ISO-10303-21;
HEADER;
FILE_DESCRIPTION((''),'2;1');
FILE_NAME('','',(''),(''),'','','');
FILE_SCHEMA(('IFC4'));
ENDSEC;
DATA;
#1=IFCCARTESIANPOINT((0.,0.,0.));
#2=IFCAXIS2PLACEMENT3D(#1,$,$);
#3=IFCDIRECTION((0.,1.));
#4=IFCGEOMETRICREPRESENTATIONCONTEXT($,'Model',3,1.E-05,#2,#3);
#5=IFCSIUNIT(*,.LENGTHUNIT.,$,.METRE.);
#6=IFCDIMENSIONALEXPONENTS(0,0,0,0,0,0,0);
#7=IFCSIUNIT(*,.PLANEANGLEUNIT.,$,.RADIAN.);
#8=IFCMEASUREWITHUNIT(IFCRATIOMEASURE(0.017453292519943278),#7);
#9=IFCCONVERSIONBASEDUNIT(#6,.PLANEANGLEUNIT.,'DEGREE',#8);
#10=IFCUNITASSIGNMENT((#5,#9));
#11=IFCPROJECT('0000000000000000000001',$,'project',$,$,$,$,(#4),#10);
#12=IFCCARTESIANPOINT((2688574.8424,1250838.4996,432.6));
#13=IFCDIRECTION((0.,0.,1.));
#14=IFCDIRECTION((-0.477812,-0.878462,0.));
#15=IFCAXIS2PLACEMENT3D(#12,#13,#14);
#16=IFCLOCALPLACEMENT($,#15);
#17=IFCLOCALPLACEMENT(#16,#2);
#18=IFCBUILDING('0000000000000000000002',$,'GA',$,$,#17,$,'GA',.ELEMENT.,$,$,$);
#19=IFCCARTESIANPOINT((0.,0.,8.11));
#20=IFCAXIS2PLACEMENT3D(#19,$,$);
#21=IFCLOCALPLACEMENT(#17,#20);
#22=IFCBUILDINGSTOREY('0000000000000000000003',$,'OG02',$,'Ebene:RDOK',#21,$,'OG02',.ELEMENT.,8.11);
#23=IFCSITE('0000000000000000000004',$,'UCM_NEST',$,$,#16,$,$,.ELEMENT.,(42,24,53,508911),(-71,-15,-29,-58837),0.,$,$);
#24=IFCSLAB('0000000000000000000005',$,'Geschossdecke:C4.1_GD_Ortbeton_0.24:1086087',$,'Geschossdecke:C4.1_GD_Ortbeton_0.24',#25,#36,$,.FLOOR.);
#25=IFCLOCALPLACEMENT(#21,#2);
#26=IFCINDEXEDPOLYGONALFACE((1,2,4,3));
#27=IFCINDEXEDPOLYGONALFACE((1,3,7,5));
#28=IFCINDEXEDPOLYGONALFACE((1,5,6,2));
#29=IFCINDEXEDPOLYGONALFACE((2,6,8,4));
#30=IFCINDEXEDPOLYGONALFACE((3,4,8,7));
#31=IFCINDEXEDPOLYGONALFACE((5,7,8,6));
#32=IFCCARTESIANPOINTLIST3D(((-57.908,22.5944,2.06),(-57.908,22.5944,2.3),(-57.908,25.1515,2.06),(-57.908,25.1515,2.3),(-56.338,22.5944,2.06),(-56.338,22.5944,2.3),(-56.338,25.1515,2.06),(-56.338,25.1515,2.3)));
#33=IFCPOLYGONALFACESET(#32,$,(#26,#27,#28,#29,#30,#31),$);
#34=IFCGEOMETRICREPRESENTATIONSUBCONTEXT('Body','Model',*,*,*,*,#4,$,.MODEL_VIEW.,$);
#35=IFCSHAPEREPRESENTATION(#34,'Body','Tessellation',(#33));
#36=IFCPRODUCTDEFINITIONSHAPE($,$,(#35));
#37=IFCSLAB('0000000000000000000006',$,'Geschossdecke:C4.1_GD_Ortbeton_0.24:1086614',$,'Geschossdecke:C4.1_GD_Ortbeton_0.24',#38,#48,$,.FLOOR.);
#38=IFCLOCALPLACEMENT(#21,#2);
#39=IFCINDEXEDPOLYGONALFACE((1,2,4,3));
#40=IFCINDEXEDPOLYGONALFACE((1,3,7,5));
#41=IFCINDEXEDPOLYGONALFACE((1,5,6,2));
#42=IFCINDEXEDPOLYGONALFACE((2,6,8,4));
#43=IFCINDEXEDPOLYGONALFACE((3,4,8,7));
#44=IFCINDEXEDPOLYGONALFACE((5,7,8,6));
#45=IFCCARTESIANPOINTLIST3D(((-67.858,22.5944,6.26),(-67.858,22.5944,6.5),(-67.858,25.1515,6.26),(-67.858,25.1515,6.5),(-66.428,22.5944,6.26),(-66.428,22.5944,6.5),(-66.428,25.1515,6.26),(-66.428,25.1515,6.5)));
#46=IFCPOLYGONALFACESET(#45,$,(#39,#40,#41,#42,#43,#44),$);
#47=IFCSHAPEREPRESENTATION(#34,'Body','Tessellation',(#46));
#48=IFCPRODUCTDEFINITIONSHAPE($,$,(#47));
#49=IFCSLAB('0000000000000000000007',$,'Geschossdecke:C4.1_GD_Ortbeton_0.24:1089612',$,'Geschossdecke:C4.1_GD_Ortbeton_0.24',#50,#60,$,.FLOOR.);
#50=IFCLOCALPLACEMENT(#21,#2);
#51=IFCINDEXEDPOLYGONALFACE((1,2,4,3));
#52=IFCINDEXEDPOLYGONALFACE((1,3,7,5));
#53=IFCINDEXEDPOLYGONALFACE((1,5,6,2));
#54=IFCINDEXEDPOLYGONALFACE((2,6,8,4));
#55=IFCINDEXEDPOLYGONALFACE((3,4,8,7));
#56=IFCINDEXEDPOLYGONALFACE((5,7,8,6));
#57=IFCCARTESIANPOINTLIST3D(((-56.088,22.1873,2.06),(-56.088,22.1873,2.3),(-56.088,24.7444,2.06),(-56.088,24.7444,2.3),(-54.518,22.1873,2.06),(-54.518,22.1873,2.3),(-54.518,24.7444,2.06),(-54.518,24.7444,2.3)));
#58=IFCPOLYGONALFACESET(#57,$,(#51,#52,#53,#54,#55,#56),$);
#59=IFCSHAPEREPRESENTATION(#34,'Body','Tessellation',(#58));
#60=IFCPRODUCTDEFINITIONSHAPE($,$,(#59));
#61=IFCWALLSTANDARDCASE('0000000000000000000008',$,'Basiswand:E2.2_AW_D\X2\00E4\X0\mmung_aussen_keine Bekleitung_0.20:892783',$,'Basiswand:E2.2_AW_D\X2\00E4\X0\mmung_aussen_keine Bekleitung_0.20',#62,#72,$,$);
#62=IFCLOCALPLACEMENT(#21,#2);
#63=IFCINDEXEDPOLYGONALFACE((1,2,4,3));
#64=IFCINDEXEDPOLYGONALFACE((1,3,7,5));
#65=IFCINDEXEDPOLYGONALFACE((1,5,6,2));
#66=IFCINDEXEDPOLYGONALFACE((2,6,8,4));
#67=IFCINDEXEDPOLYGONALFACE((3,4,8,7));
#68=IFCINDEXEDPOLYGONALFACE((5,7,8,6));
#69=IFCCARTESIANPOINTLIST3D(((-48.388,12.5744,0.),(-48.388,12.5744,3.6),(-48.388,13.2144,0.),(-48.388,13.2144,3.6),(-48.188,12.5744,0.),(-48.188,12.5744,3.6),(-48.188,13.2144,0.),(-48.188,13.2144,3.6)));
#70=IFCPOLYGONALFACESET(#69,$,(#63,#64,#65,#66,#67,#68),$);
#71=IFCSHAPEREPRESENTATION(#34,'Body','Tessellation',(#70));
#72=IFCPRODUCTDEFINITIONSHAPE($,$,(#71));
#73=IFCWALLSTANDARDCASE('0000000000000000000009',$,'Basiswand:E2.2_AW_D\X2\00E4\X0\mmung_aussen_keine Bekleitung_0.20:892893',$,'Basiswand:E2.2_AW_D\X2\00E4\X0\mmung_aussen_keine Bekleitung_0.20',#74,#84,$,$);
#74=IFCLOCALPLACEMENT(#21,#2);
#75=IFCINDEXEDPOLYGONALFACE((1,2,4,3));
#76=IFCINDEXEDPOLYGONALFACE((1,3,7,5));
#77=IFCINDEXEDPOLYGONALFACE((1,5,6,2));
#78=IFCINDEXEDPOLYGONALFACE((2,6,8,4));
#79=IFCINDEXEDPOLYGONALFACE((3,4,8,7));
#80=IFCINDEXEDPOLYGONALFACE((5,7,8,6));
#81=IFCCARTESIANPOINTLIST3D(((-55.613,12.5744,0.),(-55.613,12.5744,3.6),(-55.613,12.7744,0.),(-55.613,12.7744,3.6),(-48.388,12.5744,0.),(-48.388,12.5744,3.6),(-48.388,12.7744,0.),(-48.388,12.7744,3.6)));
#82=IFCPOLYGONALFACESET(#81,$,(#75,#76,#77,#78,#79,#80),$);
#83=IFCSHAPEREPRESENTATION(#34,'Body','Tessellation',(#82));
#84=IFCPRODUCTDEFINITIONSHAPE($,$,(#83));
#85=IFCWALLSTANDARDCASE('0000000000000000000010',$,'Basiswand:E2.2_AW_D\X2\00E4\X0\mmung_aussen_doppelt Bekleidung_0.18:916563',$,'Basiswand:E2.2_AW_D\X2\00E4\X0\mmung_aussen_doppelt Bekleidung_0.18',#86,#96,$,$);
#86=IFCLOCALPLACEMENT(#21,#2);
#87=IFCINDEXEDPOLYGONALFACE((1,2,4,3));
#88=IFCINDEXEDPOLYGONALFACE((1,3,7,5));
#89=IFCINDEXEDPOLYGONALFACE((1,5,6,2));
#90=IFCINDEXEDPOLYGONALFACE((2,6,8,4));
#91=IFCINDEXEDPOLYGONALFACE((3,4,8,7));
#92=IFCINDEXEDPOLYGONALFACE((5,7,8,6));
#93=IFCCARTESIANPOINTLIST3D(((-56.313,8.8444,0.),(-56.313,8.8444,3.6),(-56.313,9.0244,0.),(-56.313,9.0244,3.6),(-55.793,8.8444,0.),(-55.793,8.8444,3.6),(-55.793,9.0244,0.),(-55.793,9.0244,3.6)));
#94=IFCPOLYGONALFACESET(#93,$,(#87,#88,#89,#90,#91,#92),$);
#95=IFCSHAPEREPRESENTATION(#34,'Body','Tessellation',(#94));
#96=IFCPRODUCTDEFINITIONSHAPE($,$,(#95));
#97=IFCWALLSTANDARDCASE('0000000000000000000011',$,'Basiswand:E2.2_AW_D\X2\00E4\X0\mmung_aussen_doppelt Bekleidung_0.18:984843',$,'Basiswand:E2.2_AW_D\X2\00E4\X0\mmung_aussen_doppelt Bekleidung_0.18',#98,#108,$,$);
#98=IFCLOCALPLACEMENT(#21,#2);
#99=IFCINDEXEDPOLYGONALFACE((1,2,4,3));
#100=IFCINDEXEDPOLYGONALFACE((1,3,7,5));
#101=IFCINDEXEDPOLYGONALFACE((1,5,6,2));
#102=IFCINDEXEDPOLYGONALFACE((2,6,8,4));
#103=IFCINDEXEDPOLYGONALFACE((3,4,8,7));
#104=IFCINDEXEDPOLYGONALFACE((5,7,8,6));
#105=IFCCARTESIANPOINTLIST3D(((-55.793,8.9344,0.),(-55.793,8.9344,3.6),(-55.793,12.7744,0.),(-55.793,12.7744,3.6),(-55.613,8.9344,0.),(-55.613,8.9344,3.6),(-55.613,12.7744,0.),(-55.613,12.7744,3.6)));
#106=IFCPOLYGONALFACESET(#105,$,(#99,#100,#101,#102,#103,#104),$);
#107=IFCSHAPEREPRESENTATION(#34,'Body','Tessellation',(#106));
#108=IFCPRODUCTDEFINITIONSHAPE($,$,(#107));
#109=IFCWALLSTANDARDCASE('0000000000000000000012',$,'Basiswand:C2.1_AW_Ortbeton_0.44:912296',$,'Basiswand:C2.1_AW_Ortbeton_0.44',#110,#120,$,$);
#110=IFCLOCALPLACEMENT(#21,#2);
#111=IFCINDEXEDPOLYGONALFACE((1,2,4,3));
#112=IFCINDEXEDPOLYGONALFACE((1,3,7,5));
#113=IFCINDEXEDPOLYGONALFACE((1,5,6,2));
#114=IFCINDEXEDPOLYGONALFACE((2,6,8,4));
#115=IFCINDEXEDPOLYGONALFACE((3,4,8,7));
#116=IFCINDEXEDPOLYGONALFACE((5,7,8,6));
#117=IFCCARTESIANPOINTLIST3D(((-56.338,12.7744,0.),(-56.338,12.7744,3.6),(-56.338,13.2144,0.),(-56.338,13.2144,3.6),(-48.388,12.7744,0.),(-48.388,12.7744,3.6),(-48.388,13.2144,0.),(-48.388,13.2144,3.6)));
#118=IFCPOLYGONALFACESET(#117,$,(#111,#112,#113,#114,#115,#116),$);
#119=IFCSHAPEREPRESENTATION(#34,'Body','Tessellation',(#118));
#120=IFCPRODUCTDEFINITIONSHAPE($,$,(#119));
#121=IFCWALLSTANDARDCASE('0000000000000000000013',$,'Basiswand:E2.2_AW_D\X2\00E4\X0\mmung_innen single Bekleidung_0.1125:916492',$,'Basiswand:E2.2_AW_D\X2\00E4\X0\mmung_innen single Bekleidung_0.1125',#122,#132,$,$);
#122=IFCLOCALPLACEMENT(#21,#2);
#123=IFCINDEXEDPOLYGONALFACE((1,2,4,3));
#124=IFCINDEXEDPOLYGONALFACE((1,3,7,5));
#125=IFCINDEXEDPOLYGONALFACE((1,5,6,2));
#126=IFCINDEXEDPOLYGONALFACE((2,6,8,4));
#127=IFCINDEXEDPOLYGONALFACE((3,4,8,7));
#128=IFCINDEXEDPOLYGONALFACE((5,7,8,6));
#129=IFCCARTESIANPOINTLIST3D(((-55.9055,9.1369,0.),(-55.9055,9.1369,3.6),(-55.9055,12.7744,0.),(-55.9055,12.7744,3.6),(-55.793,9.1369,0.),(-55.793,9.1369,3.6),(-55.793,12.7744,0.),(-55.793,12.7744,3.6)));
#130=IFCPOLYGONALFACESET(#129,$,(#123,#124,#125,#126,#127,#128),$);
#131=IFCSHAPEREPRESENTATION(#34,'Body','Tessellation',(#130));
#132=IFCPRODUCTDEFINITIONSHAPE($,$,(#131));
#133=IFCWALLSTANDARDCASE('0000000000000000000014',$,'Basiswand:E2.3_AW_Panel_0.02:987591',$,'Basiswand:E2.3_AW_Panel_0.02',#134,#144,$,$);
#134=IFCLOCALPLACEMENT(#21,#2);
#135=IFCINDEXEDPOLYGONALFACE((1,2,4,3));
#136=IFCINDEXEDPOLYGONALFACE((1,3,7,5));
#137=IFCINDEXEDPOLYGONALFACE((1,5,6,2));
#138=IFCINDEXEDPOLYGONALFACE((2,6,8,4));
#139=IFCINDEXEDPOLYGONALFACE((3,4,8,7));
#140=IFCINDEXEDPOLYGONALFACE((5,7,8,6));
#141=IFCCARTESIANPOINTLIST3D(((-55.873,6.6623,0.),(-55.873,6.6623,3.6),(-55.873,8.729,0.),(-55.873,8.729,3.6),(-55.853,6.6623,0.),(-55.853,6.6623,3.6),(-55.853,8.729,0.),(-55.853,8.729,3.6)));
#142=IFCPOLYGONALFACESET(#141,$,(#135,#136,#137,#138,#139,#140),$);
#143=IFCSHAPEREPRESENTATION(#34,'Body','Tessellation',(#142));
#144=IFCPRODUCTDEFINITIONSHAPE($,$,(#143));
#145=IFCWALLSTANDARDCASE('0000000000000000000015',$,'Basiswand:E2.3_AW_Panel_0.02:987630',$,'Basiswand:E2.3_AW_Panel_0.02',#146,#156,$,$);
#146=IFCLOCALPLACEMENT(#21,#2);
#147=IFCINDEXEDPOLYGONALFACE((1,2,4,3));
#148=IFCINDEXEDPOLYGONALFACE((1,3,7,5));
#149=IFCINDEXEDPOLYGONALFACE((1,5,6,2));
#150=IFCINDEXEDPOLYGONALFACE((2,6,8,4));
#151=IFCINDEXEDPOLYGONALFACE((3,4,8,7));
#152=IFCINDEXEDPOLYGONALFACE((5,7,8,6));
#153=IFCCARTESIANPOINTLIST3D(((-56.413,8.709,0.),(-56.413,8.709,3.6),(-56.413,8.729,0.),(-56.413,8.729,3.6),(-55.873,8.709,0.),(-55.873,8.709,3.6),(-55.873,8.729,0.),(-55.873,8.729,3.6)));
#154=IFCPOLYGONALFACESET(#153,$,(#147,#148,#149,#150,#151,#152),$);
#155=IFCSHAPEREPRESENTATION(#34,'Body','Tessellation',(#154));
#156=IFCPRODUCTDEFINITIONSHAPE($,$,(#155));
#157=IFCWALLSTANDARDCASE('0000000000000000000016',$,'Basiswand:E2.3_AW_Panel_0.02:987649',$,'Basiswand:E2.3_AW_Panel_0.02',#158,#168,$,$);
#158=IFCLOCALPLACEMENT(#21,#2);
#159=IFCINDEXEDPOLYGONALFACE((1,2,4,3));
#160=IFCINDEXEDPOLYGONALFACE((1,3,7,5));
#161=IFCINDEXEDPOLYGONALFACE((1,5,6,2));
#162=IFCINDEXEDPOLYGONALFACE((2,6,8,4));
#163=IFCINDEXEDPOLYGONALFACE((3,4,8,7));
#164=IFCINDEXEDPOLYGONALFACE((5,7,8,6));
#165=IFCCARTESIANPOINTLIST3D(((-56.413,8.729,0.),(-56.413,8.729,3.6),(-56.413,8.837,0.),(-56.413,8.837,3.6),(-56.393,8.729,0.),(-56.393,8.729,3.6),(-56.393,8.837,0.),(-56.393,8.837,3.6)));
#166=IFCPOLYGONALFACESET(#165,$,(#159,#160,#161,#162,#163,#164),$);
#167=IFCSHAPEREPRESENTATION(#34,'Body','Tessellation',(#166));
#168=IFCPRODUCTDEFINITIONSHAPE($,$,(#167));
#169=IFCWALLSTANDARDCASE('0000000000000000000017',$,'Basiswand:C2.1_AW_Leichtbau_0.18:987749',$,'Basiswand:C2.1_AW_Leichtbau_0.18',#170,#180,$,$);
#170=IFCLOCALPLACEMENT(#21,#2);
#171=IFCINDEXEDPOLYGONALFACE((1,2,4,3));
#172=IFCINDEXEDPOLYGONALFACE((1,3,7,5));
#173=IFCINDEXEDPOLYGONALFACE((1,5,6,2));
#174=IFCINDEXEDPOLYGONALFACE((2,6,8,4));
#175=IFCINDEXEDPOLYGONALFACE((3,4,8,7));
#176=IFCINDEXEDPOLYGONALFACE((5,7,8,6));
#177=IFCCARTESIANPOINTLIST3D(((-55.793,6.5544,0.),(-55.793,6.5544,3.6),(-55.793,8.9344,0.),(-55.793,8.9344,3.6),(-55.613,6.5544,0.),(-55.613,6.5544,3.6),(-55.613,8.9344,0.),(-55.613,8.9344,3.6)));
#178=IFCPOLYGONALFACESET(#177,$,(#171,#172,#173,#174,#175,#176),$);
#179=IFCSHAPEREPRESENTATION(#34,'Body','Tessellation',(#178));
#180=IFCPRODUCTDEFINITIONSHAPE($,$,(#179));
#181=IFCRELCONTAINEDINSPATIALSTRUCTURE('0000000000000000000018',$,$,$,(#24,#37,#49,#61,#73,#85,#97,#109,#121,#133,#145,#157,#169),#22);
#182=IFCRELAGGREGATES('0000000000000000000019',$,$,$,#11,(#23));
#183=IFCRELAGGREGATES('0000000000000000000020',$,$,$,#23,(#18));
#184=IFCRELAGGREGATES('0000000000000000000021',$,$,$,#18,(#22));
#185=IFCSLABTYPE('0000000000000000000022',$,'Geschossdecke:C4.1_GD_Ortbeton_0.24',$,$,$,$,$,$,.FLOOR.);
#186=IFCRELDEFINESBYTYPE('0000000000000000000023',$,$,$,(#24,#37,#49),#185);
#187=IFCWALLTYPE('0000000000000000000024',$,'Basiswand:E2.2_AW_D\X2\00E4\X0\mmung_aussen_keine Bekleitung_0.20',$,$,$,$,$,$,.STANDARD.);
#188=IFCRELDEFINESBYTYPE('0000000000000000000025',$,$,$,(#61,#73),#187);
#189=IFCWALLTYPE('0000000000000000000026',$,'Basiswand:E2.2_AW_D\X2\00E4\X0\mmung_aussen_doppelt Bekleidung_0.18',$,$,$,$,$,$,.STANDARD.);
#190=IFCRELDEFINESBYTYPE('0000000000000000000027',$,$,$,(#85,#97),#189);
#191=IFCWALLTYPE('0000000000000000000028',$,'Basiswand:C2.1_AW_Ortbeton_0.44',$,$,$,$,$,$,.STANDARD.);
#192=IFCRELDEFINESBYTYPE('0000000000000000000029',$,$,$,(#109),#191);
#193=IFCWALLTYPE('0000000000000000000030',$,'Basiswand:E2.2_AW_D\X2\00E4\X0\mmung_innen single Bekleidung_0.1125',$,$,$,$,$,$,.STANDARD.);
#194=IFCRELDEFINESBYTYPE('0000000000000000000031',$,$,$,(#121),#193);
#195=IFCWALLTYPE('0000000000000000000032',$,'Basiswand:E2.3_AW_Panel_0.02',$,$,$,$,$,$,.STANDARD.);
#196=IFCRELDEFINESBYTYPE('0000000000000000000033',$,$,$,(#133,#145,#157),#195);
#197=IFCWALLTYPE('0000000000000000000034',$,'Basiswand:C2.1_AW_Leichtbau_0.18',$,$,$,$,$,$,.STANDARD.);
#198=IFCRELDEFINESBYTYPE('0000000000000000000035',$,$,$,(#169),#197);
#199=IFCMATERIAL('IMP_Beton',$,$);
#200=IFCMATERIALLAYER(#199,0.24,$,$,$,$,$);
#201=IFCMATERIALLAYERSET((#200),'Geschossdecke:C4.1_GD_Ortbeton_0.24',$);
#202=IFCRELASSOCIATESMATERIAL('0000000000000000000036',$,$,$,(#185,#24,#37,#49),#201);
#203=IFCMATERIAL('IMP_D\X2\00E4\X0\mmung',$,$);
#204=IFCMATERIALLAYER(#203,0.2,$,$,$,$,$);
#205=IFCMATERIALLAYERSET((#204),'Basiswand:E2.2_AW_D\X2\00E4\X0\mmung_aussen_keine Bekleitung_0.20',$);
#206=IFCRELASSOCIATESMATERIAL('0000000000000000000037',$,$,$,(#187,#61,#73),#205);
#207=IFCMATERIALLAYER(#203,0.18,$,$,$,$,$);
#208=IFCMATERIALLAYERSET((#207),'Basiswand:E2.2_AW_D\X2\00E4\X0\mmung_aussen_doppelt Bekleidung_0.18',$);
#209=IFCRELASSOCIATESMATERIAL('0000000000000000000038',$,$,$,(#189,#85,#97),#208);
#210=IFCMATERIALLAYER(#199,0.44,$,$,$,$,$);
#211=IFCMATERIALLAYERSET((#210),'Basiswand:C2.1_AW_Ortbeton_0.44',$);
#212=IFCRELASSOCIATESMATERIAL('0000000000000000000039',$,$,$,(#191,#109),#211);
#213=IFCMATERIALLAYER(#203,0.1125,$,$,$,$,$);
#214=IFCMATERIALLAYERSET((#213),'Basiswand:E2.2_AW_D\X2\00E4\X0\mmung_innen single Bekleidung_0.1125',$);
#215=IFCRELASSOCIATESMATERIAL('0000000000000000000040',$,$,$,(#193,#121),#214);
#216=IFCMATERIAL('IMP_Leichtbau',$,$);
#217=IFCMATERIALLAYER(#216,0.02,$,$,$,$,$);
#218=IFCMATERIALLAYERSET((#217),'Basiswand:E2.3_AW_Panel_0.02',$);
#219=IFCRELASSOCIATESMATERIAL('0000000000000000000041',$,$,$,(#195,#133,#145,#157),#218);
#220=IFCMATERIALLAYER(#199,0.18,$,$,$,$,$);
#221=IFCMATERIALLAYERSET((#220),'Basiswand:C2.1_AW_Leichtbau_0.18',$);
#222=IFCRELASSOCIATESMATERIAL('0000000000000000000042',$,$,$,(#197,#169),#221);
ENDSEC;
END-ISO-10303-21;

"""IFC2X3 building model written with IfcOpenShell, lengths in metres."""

from ifc_helpers import new_model, entity, si_unit, converted_unit, direction, frame, frame_2d, origin, place, context, subcontext, project, spatial, rectangle, extrude, material, layer, layer_set, layer_usage, type_object, element, save


model = new_model("IFC2X3")

# Units and contexts
model_context = context("Model", 3, precision=1e-05, world=origin(), true_north=direction((0.0, 1.0)))
body_context = subcontext(model_context, "Body", "Model", "MODEL_VIEW")
ifc_project = project(units=[si_unit("LENGTHUNIT", "METRE"), converted_unit("PLANEANGLEUNIT", "DEGREE", entity("IfcRatioMeasure", 0.017453292519943278), si_unit("PLANEANGLEUNIT", "RADIAN"), dimensions=[0, 0, 0, 0, 0, 0, 0])], contexts=[model_context])

# Site, building, storey
site_placement = place(None, frame((2688574.8424, 1250838.4996, 432.6), z_axis=(0.0, 0.0, 1.0), x_axis=(-0.477812, -0.878462, 0.0)))
site = spatial("IfcSite", under=ifc_project, at=site_placement, Name="UCM_NEST", CompositionType="ELEMENT", RefLatitude=(42, 24, 53, 508911), RefLongitude=(-71, -15, -29, -58837), RefElevation=0.0)
building_placement = place(site_placement, origin())
building = spatial("IfcBuilding", under=site, at=building_placement, Name="GA", LongName="GA", CompositionType="ELEMENT")
storey_placement = place(building_placement, frame((0.0, 0.0, 8.11)))
storey = spatial("IfcBuildingStorey", under=building, at=storey_placement, Name="OG02", ObjectType="Ebene:RDOK", LongName="OG02", CompositionType="ELEMENT", Elevation=8.11)

# Shared definitions
ifc_material_1 = material(Name="IMP_Beton")
ifc_material_2 = material(Name="IMP_Dämmung")

# Slabs
ifc_layer_1 = layer(ifc_material_1, 0.24)
ifc_layer_set_1 = layer_set([ifc_layer_1], Name="Geschossdecke:C4.1_GD_Ortbeton_0.24")
ifc_layer_usage_1 = layer_usage(ifc_layer_set_1, "AXIS3", "POSITIVE", 0.0)
slab_type_1 = type_object("IfcSlabType", Name="Geschossdecke:C4.1_GD_Ortbeton_0.24", PredefinedType="FLOOR", material=ifc_layer_set_1)
slab_1_placement = place(storey_placement, origin())
element("IfcSlab", 1, at=slab_1_placement, inside=storey, type_object=slab_type_1, material=ifc_layer_usage_1, Name="Geschossdecke:C4.1_GD_Ortbeton_0.24:1086087", ObjectType="Geschossdecke:C4.1_GD_Ortbeton_0.24", PredefinedType="FLOOR", context=body_context, shape_type="SweptSolid", body=[
    extrude(rectangle(XDim=2.5571, YDim=1.57, at=frame_2d((0.0, 0.0), x_axis=(1.0, 0.0))), frame((-57.123, 23.873, 2.3), z_axis=(0.0, 0.0, -1.0), x_axis=(0.0, 1.0, 0.0)), (0.0, 0.0, 1.0), 0.24),
])
slab_2_placement = place(storey_placement, origin())
element("IfcSlab", 2, at=slab_2_placement, inside=storey, type_object=slab_type_1, material=ifc_layer_usage_1, Name="Geschossdecke:C4.1_GD_Ortbeton_0.24:1086614", ObjectType="Geschossdecke:C4.1_GD_Ortbeton_0.24", PredefinedType="FLOOR", context=body_context, shape_type="SweptSolid", body=[
    extrude(rectangle(XDim=2.5571, YDim=1.43, at=frame_2d((0.0, 0.0), x_axis=(1.0, 0.0))), frame((-67.143, 23.873, 6.5), z_axis=(0.0, 0.0, -1.0), x_axis=(0.0, 1.0, 0.0)), (0.0, 0.0, 1.0), 0.24),
])
slab_3_placement = place(storey_placement, origin())
element("IfcSlab", 3, at=slab_3_placement, inside=storey, type_object=slab_type_1, material=ifc_layer_usage_1, Name="Geschossdecke:C4.1_GD_Ortbeton_0.24:1089612", ObjectType="Geschossdecke:C4.1_GD_Ortbeton_0.24", PredefinedType="FLOOR", context=body_context, shape_type="SweptSolid", body=[
    extrude(rectangle(XDim=2.5571, YDim=1.57, at=frame_2d((0.0, 0.0), x_axis=(1.0, 0.0))), frame((-55.303, 23.4659, 2.3), z_axis=(0.0, 0.0, -1.0), x_axis=(0.0, 1.0, 0.0)), (0.0, 0.0, 1.0), 0.24),
])

# Walls
ifc_layer_2 = layer(ifc_material_2, 0.2)
ifc_layer_set_2 = layer_set([ifc_layer_2], Name="Basiswand:E2.2_AW_Dämmung_aussen_keine Bekleitung_0.20")
ifc_layer_usage_2 = layer_usage(ifc_layer_set_2, "AXIS2", "NEGATIVE", 0.1)
wall_type_1 = type_object("IfcWallType", Name="Basiswand:E2.2_AW_Dämmung_aussen_keine Bekleitung_0.20", PredefinedType="STANDARD", material=ifc_layer_set_2)
wall_1_placement = place(storey_placement, frame((-48.288, 13.2144, 0.0), z_axis=(0.0, 0.0, 1.0), x_axis=(0.0, -1.0, 0.0)))
element("IfcWallStandardCase", 4, at=wall_1_placement, inside=storey, type_object=wall_type_1, material=ifc_layer_usage_2, Name="Basiswand:E2.2_AW_Dämmung_aussen_keine Bekleitung_0.20:892783", ObjectType="Basiswand:E2.2_AW_Dämmung_aussen_keine Bekleitung_0.20", context=body_context, shape_type="SweptSolid", body=[
    extrude(rectangle(XDim=0.64, YDim=0.2, at=frame_2d((0.32, 0.0), x_axis=(-1.0, 0.0))), origin(), (0.0, 0.0, 1.0), 3.6),
])
wall_2_placement = place(storey_placement, frame((-48.388, 12.6744, 0.0), z_axis=(0.0, 0.0, 1.0), x_axis=(-1.0, 0.0, 0.0)))
element("IfcWallStandardCase", 5, at=wall_2_placement, inside=storey, type_object=wall_type_1, material=ifc_layer_usage_2, Name="Basiswand:E2.2_AW_Dämmung_aussen_keine Bekleitung_0.20:892893", ObjectType="Basiswand:E2.2_AW_Dämmung_aussen_keine Bekleitung_0.20", context=body_context, shape_type="SweptSolid", body=[
    extrude(rectangle(XDim=7.225, YDim=0.2, at=frame_2d((3.6125, 0.0), x_axis=(-1.0, 0.0))), origin(), (0.0, 0.0, 1.0), 3.6),
])
ifc_layer_3 = layer(ifc_material_2, 0.18)
ifc_layer_set_3 = layer_set([ifc_layer_3], Name="Basiswand:E2.2_AW_Dämmung_aussen_doppelt Bekleidung_0.18")
ifc_layer_usage_3 = layer_usage(ifc_layer_set_3, "AXIS2", "NEGATIVE", 0.09)
wall_type_2 = type_object("IfcWallType", Name="Basiswand:E2.2_AW_Dämmung_aussen_doppelt Bekleidung_0.18", PredefinedType="STANDARD", material=ifc_layer_set_3)
wall_3_placement = place(storey_placement, frame((-56.313, 8.9344, 0.0)))
element("IfcWallStandardCase", 6, at=wall_3_placement, inside=storey, type_object=wall_type_2, material=ifc_layer_usage_3, Name="Basiswand:E2.2_AW_Dämmung_aussen_doppelt Bekleidung_0.18:916563", ObjectType="Basiswand:E2.2_AW_Dämmung_aussen_doppelt Bekleidung_0.18", context=body_context, shape_type="SweptSolid", body=[
    extrude(rectangle(XDim=0.52, YDim=0.18, at=frame_2d((0.26, 0.0), x_axis=(-1.0, 0.0))), origin(), (0.0, 0.0, 1.0), 3.6),
])
wall_4_placement = place(storey_placement, frame((-55.703, 8.9344, 0.0), z_axis=(0.0, 0.0, 1.0), x_axis=(0.0, 1.0, 0.0)))
element("IfcWallStandardCase", 7, at=wall_4_placement, inside=storey, type_object=wall_type_2, material=ifc_layer_usage_3, Name="Basiswand:E2.2_AW_Dämmung_aussen_doppelt Bekleidung_0.18:984843", ObjectType="Basiswand:E2.2_AW_Dämmung_aussen_doppelt Bekleidung_0.18", context=body_context, shape_type="SweptSolid", body=[
    extrude(rectangle(XDim=3.84, YDim=0.18, at=frame_2d((1.92, 0.0), x_axis=(-1.0, 0.0))), origin(), (0.0, 0.0, 1.0), 3.6),
])
ifc_layer_4 = layer(ifc_material_1, 0.44)
ifc_layer_set_4 = layer_set([ifc_layer_4], Name="Basiswand:C2.1_AW_Ortbeton_0.44")
ifc_layer_usage_4 = layer_usage(ifc_layer_set_4, "AXIS2", "NEGATIVE", 0.22)
wall_type_3 = type_object("IfcWallType", Name="Basiswand:C2.1_AW_Ortbeton_0.44", PredefinedType="STANDARD", material=ifc_layer_set_4)
wall_5_placement = place(storey_placement, frame((-48.388, 12.9944, 0.0), z_axis=(0.0, 0.0, 1.0), x_axis=(-1.0, 0.0, 0.0)))
element("IfcWallStandardCase", 8, at=wall_5_placement, inside=storey, type_object=wall_type_3, material=ifc_layer_usage_4, Name="Basiswand:C2.1_AW_Ortbeton_0.44:912296", ObjectType="Basiswand:C2.1_AW_Ortbeton_0.44", context=body_context, shape_type="SweptSolid", body=[
    extrude(rectangle(XDim=7.95, YDim=0.44, at=frame_2d((3.975, 0.0), x_axis=(-1.0, 0.0))), origin(), (0.0, 0.0, 1.0), 3.6),
])
ifc_layer_5 = layer(ifc_material_2, 0.1125)
ifc_layer_set_5 = layer_set([ifc_layer_5], Name="Basiswand:E2.2_AW_Dämmung_innen single Bekleidung_0.1125")
ifc_layer_usage_5 = layer_usage(ifc_layer_set_5, "AXIS2", "NEGATIVE", 0.0562)
wall_type_4 = type_object("IfcWallType", Name="Basiswand:E2.2_AW_Dämmung_innen single Bekleidung_0.1125", PredefinedType="STANDARD", material=ifc_layer_set_5)
wall_6_placement = place(storey_placement, frame((-55.8493, 9.1369, 0.0), z_axis=(0.0, 0.0, 1.0), x_axis=(0.0, 1.0, 0.0)))
element("IfcWallStandardCase", 9, at=wall_6_placement, inside=storey, type_object=wall_type_4, material=ifc_layer_usage_5, Name="Basiswand:E2.2_AW_Dämmung_innen single Bekleidung_0.1125:916492", ObjectType="Basiswand:E2.2_AW_Dämmung_innen single Bekleidung_0.1125", context=body_context, shape_type="SweptSolid", body=[
    extrude(rectangle(XDim=3.6375, YDim=0.1125, at=frame_2d((1.8187, 0.0), x_axis=(-1.0, 0.0))), origin(), (0.0, 0.0, 1.0), 3.6),
])
ifc_material_3 = material(Name="IMP_Leichtbau")
ifc_layer_6 = layer(ifc_material_3, 0.02)
ifc_layer_set_6 = layer_set([ifc_layer_6], Name="Basiswand:E2.3_AW_Panel_0.02")
ifc_layer_usage_6 = layer_usage(ifc_layer_set_6, "AXIS2", "NEGATIVE", 0.01)
wall_type_5 = type_object("IfcWallType", Name="Basiswand:E2.3_AW_Panel_0.02", PredefinedType="STANDARD", material=ifc_layer_set_6)
wall_7_placement = place(storey_placement, frame((-55.863, 6.6623, 0.0), z_axis=(0.0, 0.0, 1.0), x_axis=(0.0, 1.0, 0.0)))
element("IfcWallStandardCase", 10, at=wall_7_placement, inside=storey, type_object=wall_type_5, material=ifc_layer_usage_6, Name="Basiswand:E2.3_AW_Panel_0.02:987591", ObjectType="Basiswand:E2.3_AW_Panel_0.02", context=body_context, shape_type="SweptSolid", body=[
    extrude(rectangle(XDim=2.0667, YDim=0.02, at=frame_2d((1.0333, 0.0), x_axis=(-1.0, 0.0))), origin(), (0.0, 0.0, 1.0), 3.6),
])
wall_8_placement = place(storey_placement, frame((-55.873, 8.719, 0.0), z_axis=(0.0, 0.0, 1.0), x_axis=(-1.0, 0.0, 0.0)))
element("IfcWallStandardCase", 11, at=wall_8_placement, inside=storey, type_object=wall_type_5, material=ifc_layer_usage_6, Name="Basiswand:E2.3_AW_Panel_0.02:987630", ObjectType="Basiswand:E2.3_AW_Panel_0.02", context=body_context, shape_type="SweptSolid", body=[
    extrude(rectangle(XDim=0.54, YDim=0.02, at=frame_2d((0.27, 0.0), x_axis=(-1.0, 0.0))), origin(), (0.0, 0.0, 1.0), 3.6),
])
wall_9_placement = place(storey_placement, frame((-56.403, 8.729, 0.0), z_axis=(0.0, 0.0, 1.0), x_axis=(0.0, 1.0, 0.0)))
element("IfcWallStandardCase", 12, at=wall_9_placement, inside=storey, type_object=wall_type_5, material=ifc_layer_usage_6, Name="Basiswand:E2.3_AW_Panel_0.02:987649", ObjectType="Basiswand:E2.3_AW_Panel_0.02", context=body_context, shape_type="SweptSolid", body=[
    extrude(rectangle(XDim=0.108, YDim=0.02, at=frame_2d((0.054, 0.0), x_axis=(-1.0, 0.0))), origin(), (0.0, 0.0, 1.0), 3.6),
])
ifc_layer_7 = layer(ifc_material_1, 0.18)
ifc_layer_set_7 = layer_set([ifc_layer_7], Name="Basiswand:C2.1_AW_Leichtbau_0.18")
ifc_layer_usage_7 = layer_usage(ifc_layer_set_7, "AXIS2", "NEGATIVE", 0.09)
wall_type_6 = type_object("IfcWallType", Name="Basiswand:C2.1_AW_Leichtbau_0.18", PredefinedType="STANDARD", material=ifc_layer_set_7)
wall_10_placement = place(storey_placement, frame((-55.703, 6.5544, 0.0), z_axis=(0.0, 0.0, 1.0), x_axis=(0.0, 1.0, 0.0)))
element("IfcWallStandardCase", 13, at=wall_10_placement, inside=storey, type_object=wall_type_6, material=ifc_layer_usage_7, Name="Basiswand:C2.1_AW_Leichtbau_0.18:987749", ObjectType="Basiswand:C2.1_AW_Leichtbau_0.18", context=body_context, shape_type="SweptSolid", body=[
    extrude(rectangle(XDim=2.38, YDim=0.18, at=frame_2d((1.19, 0.0), x_axis=(-1.0, 0.0))), origin(), (0.0, 0.0, 1.0), 3.6),
])

save(model, "model.ifc")
